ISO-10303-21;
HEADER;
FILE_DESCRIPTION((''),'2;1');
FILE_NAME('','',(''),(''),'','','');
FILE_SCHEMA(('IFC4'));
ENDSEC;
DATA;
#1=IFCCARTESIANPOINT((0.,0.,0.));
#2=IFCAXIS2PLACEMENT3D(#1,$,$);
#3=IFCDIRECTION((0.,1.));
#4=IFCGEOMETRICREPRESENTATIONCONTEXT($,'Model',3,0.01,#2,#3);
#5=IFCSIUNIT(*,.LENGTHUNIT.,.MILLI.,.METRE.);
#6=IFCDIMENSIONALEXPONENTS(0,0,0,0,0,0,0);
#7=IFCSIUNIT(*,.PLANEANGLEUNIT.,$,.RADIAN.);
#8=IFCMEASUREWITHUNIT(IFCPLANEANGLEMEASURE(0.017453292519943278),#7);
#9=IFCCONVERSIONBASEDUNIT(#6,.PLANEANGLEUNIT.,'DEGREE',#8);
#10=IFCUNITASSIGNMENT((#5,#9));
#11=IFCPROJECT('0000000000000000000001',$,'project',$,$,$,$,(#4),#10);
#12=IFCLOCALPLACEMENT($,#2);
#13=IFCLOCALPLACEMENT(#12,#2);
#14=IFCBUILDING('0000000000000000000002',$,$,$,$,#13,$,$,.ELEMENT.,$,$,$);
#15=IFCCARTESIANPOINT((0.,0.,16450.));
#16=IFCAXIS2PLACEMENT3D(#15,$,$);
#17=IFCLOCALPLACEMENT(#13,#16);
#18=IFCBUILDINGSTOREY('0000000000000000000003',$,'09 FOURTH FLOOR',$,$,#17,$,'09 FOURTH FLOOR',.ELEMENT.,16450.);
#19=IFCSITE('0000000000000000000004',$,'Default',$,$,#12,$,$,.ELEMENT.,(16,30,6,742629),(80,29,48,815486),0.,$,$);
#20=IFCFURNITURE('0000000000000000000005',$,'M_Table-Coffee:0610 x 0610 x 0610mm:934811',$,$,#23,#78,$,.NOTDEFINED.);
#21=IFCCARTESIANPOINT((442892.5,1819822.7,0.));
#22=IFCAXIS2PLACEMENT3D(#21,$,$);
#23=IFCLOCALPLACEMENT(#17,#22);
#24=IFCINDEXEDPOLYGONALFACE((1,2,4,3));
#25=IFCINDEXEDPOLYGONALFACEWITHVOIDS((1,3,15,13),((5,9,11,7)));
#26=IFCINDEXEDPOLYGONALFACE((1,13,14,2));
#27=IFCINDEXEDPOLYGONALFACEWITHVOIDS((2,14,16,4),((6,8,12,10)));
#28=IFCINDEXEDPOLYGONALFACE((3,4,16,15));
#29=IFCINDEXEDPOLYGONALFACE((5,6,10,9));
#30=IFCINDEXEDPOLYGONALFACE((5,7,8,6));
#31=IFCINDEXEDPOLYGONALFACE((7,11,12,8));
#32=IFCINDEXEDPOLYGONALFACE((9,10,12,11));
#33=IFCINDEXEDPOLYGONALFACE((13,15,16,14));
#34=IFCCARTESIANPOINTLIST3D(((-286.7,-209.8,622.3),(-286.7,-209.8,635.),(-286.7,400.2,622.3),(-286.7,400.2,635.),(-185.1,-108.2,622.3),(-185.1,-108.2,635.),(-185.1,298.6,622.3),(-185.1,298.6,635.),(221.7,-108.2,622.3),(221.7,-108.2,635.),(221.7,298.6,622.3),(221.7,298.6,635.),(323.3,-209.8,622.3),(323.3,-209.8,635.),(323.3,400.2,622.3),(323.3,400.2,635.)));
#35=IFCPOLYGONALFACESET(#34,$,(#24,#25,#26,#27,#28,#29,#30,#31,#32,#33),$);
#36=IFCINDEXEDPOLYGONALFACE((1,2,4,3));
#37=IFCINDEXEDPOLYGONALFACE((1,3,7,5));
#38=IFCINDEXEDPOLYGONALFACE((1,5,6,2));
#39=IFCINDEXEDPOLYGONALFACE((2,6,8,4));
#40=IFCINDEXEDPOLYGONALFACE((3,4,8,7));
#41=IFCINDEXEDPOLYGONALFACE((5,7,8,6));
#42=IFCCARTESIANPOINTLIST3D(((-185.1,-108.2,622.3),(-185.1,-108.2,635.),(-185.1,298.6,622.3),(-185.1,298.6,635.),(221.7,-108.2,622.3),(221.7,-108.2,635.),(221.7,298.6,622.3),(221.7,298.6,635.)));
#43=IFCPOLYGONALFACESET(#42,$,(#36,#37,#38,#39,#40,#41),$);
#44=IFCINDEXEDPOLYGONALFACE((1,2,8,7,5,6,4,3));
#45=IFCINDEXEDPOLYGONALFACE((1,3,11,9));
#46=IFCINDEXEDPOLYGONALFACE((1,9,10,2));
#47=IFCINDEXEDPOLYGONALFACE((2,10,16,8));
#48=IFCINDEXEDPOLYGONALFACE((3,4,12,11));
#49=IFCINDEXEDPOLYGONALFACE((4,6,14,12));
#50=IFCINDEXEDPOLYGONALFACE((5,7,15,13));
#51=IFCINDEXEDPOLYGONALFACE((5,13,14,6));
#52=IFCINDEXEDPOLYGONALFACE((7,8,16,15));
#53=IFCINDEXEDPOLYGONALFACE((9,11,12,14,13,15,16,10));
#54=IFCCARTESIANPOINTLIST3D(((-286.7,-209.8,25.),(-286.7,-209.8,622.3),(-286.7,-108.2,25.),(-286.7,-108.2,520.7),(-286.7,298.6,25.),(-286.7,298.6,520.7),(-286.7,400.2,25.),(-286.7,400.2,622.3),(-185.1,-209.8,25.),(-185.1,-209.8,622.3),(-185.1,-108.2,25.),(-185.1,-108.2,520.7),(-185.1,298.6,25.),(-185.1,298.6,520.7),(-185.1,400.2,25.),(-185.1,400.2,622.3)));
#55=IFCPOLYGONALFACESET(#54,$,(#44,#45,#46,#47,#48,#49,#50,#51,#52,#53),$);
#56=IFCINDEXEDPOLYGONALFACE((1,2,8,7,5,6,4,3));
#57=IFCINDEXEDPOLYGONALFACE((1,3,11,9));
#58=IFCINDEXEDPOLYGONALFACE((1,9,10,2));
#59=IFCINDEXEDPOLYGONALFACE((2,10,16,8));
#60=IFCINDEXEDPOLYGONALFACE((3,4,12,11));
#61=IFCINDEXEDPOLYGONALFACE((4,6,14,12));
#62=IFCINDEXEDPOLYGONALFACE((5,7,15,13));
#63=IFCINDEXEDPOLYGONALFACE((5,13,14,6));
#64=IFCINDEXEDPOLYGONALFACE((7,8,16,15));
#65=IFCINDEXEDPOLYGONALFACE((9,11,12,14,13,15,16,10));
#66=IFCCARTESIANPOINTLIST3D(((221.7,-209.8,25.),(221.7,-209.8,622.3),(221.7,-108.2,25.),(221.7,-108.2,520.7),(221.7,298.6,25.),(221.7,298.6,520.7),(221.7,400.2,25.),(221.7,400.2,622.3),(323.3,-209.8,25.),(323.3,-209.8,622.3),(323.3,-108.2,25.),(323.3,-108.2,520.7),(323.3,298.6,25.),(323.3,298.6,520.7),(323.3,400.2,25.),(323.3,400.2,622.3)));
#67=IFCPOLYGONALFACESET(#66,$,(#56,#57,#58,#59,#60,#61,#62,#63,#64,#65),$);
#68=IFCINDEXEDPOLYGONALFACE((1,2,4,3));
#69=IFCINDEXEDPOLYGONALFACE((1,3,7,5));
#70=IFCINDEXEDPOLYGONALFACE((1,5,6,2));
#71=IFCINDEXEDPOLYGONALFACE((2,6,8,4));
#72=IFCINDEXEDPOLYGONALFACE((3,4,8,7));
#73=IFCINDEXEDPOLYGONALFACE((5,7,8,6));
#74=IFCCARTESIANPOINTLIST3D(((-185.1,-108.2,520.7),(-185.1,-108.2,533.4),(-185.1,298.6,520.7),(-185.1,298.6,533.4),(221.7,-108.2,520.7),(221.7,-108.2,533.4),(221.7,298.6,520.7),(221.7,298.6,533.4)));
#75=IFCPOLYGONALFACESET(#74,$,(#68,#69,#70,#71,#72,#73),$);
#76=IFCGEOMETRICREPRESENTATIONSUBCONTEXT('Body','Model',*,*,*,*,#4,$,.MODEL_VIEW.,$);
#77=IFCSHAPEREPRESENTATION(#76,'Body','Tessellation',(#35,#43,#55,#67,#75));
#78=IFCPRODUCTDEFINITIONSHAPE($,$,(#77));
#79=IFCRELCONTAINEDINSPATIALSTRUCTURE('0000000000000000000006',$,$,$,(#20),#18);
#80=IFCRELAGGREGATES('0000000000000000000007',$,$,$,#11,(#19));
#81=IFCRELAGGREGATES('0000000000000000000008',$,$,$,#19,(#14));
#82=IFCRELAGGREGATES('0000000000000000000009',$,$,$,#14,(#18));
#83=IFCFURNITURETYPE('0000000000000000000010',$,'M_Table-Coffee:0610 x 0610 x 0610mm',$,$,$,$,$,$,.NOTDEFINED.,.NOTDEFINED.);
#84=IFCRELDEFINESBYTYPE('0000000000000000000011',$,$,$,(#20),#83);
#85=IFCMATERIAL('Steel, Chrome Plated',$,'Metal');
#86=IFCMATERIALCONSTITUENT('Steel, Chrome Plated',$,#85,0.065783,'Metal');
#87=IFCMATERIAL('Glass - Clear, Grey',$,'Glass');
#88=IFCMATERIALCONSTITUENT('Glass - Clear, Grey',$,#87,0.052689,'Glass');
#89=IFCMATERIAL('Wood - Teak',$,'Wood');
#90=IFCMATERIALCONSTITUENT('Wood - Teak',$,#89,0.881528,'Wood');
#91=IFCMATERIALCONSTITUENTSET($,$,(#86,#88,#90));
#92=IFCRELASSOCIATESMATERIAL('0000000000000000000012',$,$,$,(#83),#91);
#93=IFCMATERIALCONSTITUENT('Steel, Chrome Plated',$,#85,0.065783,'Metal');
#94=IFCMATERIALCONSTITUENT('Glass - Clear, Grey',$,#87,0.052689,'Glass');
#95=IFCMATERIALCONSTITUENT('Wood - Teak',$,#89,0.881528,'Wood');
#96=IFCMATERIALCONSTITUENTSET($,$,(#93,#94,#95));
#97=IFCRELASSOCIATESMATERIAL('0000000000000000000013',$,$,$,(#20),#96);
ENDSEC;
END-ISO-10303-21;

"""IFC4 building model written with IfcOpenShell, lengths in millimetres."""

from ifc_helpers import new_model, entity, si_unit, converted_unit, direction, frame, origin, place, context, subcontext, project, spatial, indexed_curve, outline, extrude, source, transform, mapped, material, constituent, constituent_set, type_object, type_shapes, element, save


model = new_model("IFC4")

# Units and contexts
model_context = context("Model", 3, precision=0.01, world=origin(), true_north=direction((0.0, 1.0)))
body_context = subcontext(model_context, "Body", "Model", "MODEL_VIEW")
ifc_project = project(units=[si_unit("LENGTHUNIT", "METRE", prefix="MILLI"), converted_unit("PLANEANGLEUNIT", "DEGREE", entity("IfcPlaneAngleMeasure", 0.017453292519943278), si_unit("PLANEANGLEUNIT", "RADIAN"), dimensions=[0, 0, 0, 0, 0, 0, 0])], contexts=[model_context])

# Site, building, storey
site_placement = place(None, origin())
site = spatial("IfcSite", under=ifc_project, at=site_placement, Name="Default", CompositionType="ELEMENT", RefLatitude=(16, 30, 6, 742629), RefLongitude=(80, 29, 48, 815486), RefElevation=0.0)
building_placement = place(site_placement, origin())
building = spatial("IfcBuilding", under=site, at=building_placement, CompositionType="ELEMENT")
storey_placement = place(building_placement, frame((0.0, 0.0, 16450.0)))
storey = spatial("IfcBuildingStorey", under=building, at=storey_placement, Name="09 FOURTH FLOOR", LongName="09 FOURTH FLOOR", CompositionType="ELEMENT", Elevation=16450.0)

# Furniture
ifc_material_1 = material(Name="Steel, Chrome Plated", Category="Metal")
ifc_constituent_1 = constituent(ifc_material_1, Name="Steel, Chrome Plated", Category="Metal", fraction=0.065783)
ifc_material_2 = material(Name="Glass - Clear, Grey", Category="Glass")
ifc_constituent_2 = constituent(ifc_material_2, Name="Glass - Clear, Grey", Category="Glass", fraction=0.052689)
ifc_material_3 = material(Name="Wood - Teak", Category="Wood")
ifc_constituent_3 = constituent(ifc_material_3, Name="Wood - Teak", Category="Wood", fraction=0.881528)
ifc_constituent_set_1 = constituent_set(constituents=[ifc_constituent_1, ifc_constituent_2, ifc_constituent_3])
ifc_constituent_4 = constituent(ifc_material_1, Name="Steel, Chrome Plated", Category="Metal", fraction=0.065783)
ifc_constituent_5 = constituent(ifc_material_2, Name="Glass - Clear, Grey", Category="Glass", fraction=0.052689)
ifc_constituent_6 = constituent(ifc_material_3, Name="Wood - Teak", Category="Wood", fraction=0.881528)
ifc_constituent_set_2 = constituent_set(constituents=[ifc_constituent_4, ifc_constituent_5, ifc_constituent_6])
furniture_type_1 = type_object("IfcFurnitureType", Name="M_Table-Coffee:0610 x 0610 x 0610mm", AssemblyPlace="NOTDEFINED", PredefinedType="NOTDEFINED", material=ifc_constituent_set_2)
shared_shape_1 = source(origin(), body_context, "Body", "SweptSolid", [
    extrude(outline(indexed_curve([(-305.0, -305.0), (305.0, -305.0), (305.0, 305.0), (-305.0, 305.0), (-305.0, -305.0)], self_intersect=False), holes=[indexed_curve([(-203.4, -203.4), (-203.4, 203.4), (203.4, 203.4), (203.4, -203.4), (-203.4, -203.4)], self_intersect=False)]), frame((18.3, 95.2, 622.3), z_axis=(0.0, 0.0, 1.0), x_axis=(-1.0, 0.0, 0.0)), (0.0, 0.0, 1.0), 12.7),
    extrude(outline(indexed_curve([(-203.4, -203.4), (203.4, -203.4), (203.4, 203.4), (-203.4, 203.4), (-203.4, -203.4)], self_intersect=False)), frame((18.3, 95.2, 622.3), z_axis=(0.0, 0.0, 1.0), x_axis=(-1.0, 0.0, 0.0)), (0.0, 0.0, 1.0), 12.7),
    extrude(outline(indexed_curve([(-305.0, -324.1), (305.0, -324.1), (305.0, 273.3), (203.4, 273.3), (203.4, -222.4), (-203.4, -222.4), (-203.4, 273.3), (-305.0, 273.3), (-305.0, -324.1)], self_intersect=False)), frame((-286.7, 95.2, 298.3), z_axis=(1.0, 0.0, 0.0), x_axis=(0.0, -1.0, 0.0)), (0.0, 0.0, 1.0), 101.6),
    extrude(outline(indexed_curve([(-273.2, -305.0), (324.0, -305.0), (324.0, 305.0), (-273.2, 305.0), (-273.2, 203.4), (222.5, 203.4), (222.5, -203.4), (-273.2, -203.4), (-273.2, -305.0)], self_intersect=False)), frame((221.7, 95.2, 298.2), z_axis=(1.0, 0.0, 0.0), x_axis=(0.0, 0.0, 1.0)), (0.0, 0.0, 1.0), 101.6),
    extrude(outline(indexed_curve([(-203.4, -203.4), (203.4, -203.4), (203.4, 203.4), (-203.4, 203.4), (-203.4, -203.4)], self_intersect=False)), frame((18.3, 95.2, 520.7), z_axis=(0.0, 0.0, 1.0), x_axis=(-1.0, 0.0, 0.0)), (0.0, 0.0, 1.0), 12.7),
])
type_shapes(furniture_type_1, [shared_shape_1])
furniture_1_placement = place(storey_placement, frame((442892.5, 1819822.7, 0.0)))
element("IfcFurniture", 1, at=furniture_1_placement, inside=storey, type_object=furniture_type_1, material=ifc_constituent_set_1, Name="M_Table-Coffee:0610 x 0610 x 0610mm:934811", PredefinedType="NOTDEFINED", context=body_context, shape_type="MappedRepresentation", body=[
    mapped(shared_shape_1, transform((0.0, 0.0, 0.0), scale=1.0)),
])

save(model, "model.ifc")
